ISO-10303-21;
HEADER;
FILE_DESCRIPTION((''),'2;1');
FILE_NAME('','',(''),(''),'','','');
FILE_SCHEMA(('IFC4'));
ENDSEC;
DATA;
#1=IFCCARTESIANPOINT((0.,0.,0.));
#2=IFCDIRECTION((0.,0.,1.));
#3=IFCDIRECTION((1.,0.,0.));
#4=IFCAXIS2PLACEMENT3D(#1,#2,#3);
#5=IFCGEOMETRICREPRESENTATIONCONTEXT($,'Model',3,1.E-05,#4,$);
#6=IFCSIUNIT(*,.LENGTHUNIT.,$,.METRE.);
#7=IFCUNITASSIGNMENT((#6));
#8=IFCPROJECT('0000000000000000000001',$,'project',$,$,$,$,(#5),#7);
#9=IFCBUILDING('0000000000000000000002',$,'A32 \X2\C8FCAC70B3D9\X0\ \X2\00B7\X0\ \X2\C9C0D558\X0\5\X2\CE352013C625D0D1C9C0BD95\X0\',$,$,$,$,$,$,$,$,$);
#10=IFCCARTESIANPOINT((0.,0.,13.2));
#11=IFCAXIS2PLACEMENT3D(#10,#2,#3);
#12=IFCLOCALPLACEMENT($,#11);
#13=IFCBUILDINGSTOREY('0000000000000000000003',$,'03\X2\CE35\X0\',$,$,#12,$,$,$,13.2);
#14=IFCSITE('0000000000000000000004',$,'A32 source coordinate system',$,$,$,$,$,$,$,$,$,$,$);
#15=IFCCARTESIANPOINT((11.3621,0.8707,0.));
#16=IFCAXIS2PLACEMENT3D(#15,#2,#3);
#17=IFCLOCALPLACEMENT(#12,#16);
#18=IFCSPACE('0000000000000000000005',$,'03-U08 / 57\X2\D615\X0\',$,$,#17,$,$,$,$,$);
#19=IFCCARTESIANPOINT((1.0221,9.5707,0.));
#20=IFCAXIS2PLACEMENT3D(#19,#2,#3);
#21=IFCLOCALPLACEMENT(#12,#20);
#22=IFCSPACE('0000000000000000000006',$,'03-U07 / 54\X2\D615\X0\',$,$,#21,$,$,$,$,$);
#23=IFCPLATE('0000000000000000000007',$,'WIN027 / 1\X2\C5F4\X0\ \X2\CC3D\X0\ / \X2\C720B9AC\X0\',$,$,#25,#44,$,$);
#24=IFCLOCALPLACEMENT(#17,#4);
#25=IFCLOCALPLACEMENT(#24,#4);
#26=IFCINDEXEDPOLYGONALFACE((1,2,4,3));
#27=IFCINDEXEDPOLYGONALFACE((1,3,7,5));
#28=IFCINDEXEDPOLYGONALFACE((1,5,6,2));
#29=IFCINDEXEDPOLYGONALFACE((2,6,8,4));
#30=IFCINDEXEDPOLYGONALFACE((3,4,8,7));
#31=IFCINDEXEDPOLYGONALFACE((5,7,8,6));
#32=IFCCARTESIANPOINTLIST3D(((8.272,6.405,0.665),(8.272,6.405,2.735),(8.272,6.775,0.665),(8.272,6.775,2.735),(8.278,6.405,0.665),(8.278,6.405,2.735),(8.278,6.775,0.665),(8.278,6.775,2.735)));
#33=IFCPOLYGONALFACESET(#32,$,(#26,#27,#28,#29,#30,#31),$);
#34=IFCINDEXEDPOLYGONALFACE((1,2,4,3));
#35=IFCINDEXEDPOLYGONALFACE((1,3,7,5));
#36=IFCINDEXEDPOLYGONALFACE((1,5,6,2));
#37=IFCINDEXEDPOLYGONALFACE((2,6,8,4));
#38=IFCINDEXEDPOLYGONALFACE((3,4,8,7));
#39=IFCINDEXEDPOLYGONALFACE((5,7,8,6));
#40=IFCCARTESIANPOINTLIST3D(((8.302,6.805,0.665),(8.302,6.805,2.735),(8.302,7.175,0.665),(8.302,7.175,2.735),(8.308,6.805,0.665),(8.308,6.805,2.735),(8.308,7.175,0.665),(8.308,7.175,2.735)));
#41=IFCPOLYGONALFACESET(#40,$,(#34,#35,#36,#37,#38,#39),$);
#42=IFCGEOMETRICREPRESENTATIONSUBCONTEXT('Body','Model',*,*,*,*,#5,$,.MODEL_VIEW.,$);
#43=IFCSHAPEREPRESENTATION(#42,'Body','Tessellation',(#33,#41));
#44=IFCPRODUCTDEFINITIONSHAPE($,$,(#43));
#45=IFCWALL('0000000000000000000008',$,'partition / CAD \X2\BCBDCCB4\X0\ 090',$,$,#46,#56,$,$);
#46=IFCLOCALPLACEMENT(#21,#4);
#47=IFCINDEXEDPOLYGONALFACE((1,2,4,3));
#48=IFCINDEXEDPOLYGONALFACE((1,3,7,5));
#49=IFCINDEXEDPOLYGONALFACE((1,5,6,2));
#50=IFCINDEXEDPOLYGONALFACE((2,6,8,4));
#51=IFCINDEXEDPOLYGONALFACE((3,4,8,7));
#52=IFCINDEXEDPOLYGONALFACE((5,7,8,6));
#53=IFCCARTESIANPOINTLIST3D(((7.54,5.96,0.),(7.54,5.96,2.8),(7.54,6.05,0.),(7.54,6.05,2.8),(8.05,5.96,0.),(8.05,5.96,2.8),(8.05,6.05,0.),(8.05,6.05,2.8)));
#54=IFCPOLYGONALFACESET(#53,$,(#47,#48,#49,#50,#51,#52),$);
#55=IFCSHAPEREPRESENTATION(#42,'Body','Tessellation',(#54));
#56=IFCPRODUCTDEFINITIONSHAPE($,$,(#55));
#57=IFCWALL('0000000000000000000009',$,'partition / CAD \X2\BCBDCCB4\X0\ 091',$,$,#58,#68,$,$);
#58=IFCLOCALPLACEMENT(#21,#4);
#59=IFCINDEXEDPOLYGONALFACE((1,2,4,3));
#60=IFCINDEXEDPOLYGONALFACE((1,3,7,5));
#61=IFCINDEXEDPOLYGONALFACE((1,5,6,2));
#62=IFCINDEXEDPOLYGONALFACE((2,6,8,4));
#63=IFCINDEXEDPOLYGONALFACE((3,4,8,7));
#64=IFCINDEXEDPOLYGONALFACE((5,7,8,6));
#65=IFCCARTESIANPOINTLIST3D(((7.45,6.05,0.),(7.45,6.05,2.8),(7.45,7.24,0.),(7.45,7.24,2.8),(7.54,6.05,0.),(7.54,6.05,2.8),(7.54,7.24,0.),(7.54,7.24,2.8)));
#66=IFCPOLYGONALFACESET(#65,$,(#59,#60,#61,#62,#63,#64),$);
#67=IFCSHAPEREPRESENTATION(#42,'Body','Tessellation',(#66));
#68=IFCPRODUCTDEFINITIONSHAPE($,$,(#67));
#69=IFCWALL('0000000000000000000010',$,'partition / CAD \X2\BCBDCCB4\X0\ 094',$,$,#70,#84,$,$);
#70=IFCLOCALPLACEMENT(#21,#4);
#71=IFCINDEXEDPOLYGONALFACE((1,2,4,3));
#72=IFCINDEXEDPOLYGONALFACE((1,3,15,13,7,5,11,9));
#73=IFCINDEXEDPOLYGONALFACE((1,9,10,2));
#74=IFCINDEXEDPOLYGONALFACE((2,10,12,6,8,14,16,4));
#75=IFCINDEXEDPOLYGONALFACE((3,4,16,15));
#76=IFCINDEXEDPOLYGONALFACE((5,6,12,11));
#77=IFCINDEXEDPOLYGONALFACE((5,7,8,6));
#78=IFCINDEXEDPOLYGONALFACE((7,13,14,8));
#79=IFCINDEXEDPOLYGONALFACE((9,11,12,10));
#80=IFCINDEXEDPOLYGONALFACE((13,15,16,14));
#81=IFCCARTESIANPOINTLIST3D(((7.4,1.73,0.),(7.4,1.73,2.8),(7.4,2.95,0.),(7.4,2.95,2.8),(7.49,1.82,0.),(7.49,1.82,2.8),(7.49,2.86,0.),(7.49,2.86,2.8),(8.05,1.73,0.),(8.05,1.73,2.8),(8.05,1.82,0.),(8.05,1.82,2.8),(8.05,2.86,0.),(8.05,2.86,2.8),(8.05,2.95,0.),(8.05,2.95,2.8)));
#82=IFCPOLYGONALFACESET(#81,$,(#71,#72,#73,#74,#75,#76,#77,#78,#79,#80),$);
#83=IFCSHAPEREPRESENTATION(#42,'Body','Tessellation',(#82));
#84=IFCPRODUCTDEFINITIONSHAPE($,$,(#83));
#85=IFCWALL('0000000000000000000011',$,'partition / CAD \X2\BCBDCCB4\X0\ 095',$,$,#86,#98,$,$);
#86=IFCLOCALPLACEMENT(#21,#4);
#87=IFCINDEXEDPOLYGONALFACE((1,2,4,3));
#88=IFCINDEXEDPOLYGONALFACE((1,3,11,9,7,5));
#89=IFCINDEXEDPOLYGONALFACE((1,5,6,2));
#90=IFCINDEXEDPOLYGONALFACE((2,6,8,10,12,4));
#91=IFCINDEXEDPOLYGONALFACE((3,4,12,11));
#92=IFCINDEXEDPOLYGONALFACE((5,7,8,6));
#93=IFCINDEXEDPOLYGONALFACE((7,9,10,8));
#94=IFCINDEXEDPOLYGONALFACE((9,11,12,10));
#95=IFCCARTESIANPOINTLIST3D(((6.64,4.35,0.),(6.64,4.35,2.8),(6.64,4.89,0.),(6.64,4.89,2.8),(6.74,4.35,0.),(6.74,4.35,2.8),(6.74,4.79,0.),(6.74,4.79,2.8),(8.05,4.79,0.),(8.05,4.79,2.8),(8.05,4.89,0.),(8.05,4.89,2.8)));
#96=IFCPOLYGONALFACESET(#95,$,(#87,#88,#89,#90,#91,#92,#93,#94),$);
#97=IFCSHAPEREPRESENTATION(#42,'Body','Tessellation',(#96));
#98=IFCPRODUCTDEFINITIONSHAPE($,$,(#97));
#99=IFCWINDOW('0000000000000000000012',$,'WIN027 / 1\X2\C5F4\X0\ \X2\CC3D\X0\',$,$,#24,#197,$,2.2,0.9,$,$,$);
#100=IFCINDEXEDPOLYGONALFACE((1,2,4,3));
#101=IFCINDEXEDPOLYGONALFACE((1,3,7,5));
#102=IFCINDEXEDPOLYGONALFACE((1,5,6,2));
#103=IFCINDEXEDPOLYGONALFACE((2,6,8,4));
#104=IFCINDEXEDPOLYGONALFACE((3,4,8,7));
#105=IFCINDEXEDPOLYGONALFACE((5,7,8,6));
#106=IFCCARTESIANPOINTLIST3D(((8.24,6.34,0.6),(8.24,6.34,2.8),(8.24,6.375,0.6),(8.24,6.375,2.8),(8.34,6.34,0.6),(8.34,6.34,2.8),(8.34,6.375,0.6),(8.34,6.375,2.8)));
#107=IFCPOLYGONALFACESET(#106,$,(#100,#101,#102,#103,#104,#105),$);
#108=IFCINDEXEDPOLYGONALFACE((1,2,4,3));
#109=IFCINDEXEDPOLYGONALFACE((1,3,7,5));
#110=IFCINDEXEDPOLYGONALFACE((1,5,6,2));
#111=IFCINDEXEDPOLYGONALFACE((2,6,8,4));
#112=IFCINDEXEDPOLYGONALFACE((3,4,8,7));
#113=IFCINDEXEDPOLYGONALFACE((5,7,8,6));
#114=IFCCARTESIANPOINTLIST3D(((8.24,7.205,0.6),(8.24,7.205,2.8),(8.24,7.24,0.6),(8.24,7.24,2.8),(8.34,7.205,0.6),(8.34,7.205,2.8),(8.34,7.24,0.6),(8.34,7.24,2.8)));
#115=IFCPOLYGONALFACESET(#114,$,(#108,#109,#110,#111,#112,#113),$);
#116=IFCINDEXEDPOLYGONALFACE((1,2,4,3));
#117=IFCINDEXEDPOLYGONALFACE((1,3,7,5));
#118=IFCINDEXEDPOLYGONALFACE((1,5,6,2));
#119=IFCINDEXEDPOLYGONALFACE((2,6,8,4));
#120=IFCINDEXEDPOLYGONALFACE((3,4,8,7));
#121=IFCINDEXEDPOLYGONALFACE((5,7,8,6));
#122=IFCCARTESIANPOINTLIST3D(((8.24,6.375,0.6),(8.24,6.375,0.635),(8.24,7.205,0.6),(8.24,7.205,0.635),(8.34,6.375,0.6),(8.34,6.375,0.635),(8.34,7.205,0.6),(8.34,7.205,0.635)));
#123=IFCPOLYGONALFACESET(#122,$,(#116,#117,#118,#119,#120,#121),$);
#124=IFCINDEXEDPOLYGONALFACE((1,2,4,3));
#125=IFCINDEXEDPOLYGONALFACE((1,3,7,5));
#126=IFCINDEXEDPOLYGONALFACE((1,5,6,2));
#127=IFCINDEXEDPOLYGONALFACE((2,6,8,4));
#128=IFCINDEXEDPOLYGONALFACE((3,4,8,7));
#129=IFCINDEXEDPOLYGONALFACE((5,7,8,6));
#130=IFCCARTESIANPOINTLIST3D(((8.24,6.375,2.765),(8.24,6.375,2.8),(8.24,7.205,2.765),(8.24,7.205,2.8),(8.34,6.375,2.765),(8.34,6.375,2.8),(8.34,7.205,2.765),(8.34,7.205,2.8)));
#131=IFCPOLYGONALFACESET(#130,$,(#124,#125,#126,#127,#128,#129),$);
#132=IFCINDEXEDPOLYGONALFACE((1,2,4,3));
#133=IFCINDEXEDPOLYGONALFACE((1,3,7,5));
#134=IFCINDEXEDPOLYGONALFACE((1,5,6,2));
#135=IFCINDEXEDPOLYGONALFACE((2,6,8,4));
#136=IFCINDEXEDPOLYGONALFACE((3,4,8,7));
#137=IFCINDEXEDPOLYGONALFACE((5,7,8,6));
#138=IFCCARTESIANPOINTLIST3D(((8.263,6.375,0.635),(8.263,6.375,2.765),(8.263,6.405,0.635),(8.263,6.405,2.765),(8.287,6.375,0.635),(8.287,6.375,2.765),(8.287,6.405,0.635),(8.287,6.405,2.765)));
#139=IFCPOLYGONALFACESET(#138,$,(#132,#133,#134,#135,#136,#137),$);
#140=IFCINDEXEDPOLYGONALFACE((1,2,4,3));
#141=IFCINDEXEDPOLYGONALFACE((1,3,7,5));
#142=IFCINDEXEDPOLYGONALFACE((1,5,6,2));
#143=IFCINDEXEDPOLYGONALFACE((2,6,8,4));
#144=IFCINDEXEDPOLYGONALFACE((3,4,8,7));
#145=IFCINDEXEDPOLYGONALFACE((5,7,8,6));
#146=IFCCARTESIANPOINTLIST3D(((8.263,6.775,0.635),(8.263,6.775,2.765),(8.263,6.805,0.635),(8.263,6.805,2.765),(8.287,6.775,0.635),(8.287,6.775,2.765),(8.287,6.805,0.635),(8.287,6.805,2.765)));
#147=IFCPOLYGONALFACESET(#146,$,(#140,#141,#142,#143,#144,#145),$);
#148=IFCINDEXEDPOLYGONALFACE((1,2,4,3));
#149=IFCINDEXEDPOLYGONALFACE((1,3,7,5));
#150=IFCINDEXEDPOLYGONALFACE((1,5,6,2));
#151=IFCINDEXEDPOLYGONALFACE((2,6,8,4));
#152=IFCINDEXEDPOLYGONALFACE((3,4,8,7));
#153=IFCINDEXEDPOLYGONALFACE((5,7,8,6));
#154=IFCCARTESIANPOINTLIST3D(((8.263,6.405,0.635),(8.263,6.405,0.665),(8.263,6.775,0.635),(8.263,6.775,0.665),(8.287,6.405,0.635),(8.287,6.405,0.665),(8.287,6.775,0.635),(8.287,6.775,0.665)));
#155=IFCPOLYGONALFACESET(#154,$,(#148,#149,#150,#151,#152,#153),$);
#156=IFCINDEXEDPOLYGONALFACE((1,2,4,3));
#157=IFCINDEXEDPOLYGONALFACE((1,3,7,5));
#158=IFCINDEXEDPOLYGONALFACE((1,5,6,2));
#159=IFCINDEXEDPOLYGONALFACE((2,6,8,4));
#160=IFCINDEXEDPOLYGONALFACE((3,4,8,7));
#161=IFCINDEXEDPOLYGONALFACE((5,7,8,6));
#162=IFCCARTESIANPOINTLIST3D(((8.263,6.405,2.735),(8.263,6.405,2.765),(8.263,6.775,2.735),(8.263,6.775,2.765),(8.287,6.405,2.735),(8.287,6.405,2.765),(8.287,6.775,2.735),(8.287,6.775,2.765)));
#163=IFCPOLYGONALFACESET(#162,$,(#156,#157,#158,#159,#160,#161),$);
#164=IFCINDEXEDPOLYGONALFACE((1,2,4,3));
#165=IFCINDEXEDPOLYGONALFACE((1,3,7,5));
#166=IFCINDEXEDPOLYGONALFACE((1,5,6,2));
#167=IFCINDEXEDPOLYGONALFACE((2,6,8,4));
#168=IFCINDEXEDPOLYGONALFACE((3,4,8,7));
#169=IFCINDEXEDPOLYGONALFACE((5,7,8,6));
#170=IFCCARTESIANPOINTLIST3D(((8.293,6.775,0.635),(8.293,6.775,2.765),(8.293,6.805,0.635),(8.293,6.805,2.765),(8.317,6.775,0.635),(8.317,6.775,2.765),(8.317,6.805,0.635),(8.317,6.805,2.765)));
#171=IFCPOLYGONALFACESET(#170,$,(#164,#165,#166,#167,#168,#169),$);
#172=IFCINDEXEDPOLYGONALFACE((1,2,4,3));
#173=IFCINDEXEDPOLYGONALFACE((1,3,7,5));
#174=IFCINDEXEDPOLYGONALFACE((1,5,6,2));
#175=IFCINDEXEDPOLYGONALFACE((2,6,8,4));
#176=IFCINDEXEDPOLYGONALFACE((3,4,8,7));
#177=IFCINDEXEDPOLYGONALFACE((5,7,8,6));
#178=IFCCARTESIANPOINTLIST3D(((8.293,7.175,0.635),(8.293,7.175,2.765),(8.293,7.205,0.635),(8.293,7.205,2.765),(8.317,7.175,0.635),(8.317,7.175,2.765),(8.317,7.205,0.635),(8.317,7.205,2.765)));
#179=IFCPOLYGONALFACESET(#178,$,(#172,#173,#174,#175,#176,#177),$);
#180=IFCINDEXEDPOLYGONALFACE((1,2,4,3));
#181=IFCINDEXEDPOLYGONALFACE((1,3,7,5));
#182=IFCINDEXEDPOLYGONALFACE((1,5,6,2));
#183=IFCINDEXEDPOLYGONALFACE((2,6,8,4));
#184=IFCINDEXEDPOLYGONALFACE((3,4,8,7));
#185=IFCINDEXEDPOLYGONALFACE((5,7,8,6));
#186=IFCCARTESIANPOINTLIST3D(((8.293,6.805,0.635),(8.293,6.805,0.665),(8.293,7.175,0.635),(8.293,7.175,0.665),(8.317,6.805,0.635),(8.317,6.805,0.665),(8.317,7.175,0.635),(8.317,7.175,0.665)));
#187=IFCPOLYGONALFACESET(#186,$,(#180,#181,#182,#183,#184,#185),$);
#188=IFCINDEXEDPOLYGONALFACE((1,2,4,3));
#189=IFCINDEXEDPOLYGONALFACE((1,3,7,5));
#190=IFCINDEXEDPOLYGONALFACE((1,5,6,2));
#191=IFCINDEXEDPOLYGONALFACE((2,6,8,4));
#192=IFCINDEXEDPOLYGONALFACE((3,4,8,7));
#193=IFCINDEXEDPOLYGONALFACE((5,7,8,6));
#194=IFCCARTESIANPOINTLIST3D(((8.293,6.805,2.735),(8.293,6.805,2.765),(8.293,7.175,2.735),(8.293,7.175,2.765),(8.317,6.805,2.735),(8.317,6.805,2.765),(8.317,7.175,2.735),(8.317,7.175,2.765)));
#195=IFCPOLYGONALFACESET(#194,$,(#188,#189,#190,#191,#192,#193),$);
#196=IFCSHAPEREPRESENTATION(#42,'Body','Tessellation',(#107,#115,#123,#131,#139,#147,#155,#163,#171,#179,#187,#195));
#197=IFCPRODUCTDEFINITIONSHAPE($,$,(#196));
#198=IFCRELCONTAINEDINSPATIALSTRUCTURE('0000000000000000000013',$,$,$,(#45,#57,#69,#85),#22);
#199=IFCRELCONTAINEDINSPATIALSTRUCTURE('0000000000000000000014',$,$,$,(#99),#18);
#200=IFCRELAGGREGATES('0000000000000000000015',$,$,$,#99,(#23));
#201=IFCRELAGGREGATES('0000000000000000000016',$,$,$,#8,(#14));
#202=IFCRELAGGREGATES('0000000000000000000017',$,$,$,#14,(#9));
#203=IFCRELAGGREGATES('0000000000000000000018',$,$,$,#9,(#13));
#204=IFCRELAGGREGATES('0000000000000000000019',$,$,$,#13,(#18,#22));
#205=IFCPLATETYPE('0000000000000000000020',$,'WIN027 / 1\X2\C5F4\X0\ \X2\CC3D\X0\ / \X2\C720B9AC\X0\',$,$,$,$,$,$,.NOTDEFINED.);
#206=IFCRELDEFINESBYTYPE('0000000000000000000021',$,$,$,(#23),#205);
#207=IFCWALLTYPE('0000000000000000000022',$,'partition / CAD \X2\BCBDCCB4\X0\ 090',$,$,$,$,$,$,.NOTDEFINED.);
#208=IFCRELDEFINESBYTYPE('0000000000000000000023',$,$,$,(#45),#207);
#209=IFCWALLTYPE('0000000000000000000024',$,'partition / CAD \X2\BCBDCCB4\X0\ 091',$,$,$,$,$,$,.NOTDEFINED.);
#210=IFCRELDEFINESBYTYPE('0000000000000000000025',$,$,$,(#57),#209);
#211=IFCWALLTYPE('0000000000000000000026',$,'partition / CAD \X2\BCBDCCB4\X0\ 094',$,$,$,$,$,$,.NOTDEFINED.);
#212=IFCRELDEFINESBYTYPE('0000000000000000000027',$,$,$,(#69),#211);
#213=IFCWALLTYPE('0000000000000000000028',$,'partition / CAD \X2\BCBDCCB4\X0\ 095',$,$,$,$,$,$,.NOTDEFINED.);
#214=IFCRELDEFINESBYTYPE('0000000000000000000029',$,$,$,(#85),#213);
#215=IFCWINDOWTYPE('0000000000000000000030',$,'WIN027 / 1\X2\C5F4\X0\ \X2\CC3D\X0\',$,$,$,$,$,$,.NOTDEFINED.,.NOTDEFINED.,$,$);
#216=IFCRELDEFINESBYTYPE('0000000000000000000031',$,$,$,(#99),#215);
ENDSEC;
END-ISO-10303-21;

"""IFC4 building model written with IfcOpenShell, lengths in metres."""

from ifc_helpers import new_model, si_unit, frame, origin, origin_with_axes, place, context, subcontext, project, spatial, polyline, outline, extrude, source, transform, mapped, type_object, type_shapes, element, aggregate, save


model = new_model("IFC4")

# Units and contexts
model_context = context("Model", 3, precision=1e-05, world=origin_with_axes())
body_context = subcontext(model_context, "Body", "Model", "MODEL_VIEW")
ifc_project = project(units=[si_unit("LENGTHUNIT", "METRE")], contexts=[model_context])

# Plate
plate_type = type_object("IfcPlateType", Name="WIN027 / 1열 창 / 유리", PredefinedType="NOTDEFINED")
shared_shape_1 = source(origin(), body_context, "Body", "SweptSolid", [
    extrude(outline(polyline([(8.272, 6.405), (8.272, 6.775), (8.278, 6.775), (8.278, 6.405), (8.272, 6.405)])), frame((0.0, 0.0, 0.665)), (0.0, 0.0, 1.0), 2.07),
    extrude(outline(polyline([(8.302, 6.805), (8.302, 7.175), (8.308, 7.175), (8.308, 6.805), (8.302, 6.805)])), frame((0.0, 0.0, 0.665)), (0.0, 0.0, 1.0), 2.07),
])
type_shapes(plate_type, [shared_shape_1])
storey_placement = place(None, frame((0.0, 0.0, 13.2), z_axis=(0.0, 0.0, 1.0), x_axis=(1.0, 0.0, 0.0)))
space_1_placement = place(storey_placement, frame((11.3621, 0.8707, 0.0), z_axis=(0.0, 0.0, 1.0), x_axis=(1.0, 0.0, 0.0)))
window_placement = place(space_1_placement, origin_with_axes())
plate_placement = place(window_placement, origin_with_axes())
plate = element("IfcPlate", 1, at=plate_placement, type_object=plate_type, Name="WIN027 / 1열 창 / 유리", context=body_context, shape_type="MappedRepresentation", body=[
    mapped(shared_shape_1, transform((0.0, 0.0, 0.0), scale=1.0)),
])

# Site, building, storey, space
site = spatial("IfcSite", under=ifc_project, Name="A32 source coordinate system")
building = spatial("IfcBuilding", under=site, Name="A32 주거동 · 지하5층–옥탑지붕")
storey = spatial("IfcBuildingStorey", under=building, at=storey_placement, Name="03층", Elevation=13.2)
space_1 = spatial("IfcSpace", under=storey, at=space_1_placement, Name="03-U08 / 57형")

# Shared definitions
space_2_placement = place(storey_placement, frame((1.0221, 9.5707, 0.0), z_axis=(0.0, 0.0, 1.0), x_axis=(1.0, 0.0, 0.0)))
space_2 = spatial("IfcSpace", under=storey, at=space_2_placement, Name="03-U07 / 54형")

# Walls
wall_type_1 = type_object("IfcWallType", Name="partition / CAD 벽체 090", PredefinedType="NOTDEFINED")
shared_shape_2 = source(origin(), body_context, "Body", "SweptSolid", [
    extrude(outline(polyline([(7.54, 5.96), (7.54, 6.05), (8.05, 6.05), (8.05, 5.96), (7.54, 5.96)])), origin(), (0.0, 0.0, 1.0), 2.8),
])
type_shapes(wall_type_1, [shared_shape_2])
wall_1_placement = place(space_2_placement, origin_with_axes())
element("IfcWall", 2, at=wall_1_placement, inside=space_2, type_object=wall_type_1, Name="partition / CAD 벽체 090", context=body_context, shape_type="MappedRepresentation", body=[
    mapped(shared_shape_2, transform((0.0, 0.0, 0.0), scale=1.0)),
])
wall_type_2 = type_object("IfcWallType", Name="partition / CAD 벽체 091", PredefinedType="NOTDEFINED")
shared_shape_3 = source(origin(), body_context, "Body", "SweptSolid", [
    extrude(outline(polyline([(7.54, 6.05), (7.45, 6.05), (7.45, 7.24), (7.54, 7.24), (7.54, 6.05)])), origin(), (0.0, 0.0, 1.0), 2.8),
])
type_shapes(wall_type_2, [shared_shape_3])
wall_2_placement = place(space_2_placement, origin_with_axes())
element("IfcWall", 3, at=wall_2_placement, inside=space_2, type_object=wall_type_2, Name="partition / CAD 벽체 091", context=body_context, shape_type="MappedRepresentation", body=[
    mapped(shared_shape_3, transform((0.0, 0.0, 0.0), scale=1.0)),
])
wall_type_3 = type_object("IfcWallType", Name="partition / CAD 벽체 094", PredefinedType="NOTDEFINED")
shared_shape_4 = source(origin(), body_context, "Body", "SweptSolid", [
    extrude(outline(polyline([(8.05, 1.73), (7.4, 1.73), (7.4, 2.95), (8.05, 2.95), (8.05, 2.86), (7.49, 2.86), (7.49, 1.82), (8.05, 1.82), (8.05, 1.73)])), origin(), (0.0, 0.0, 1.0), 2.8),
])
type_shapes(wall_type_3, [shared_shape_4])
wall_3_placement = place(space_2_placement, origin_with_axes())
element("IfcWall", 4, at=wall_3_placement, inside=space_2, type_object=wall_type_3, Name="partition / CAD 벽체 094", context=body_context, shape_type="MappedRepresentation", body=[
    mapped(shared_shape_4, transform((0.0, 0.0, 0.0), scale=1.0)),
])
wall_type_4 = type_object("IfcWallType", Name="partition / CAD 벽체 095", PredefinedType="NOTDEFINED")
shared_shape_5 = source(origin(), body_context, "Body", "SweptSolid", [
    extrude(outline(polyline([(6.64, 4.89), (8.05, 4.89), (8.05, 4.79), (6.74, 4.79), (6.74, 4.35), (6.64, 4.35), (6.64, 4.89)])), origin(), (0.0, 0.0, 1.0), 2.8),
])
type_shapes(wall_type_4, [shared_shape_5])
wall_4_placement = place(space_2_placement, origin_with_axes())
element("IfcWall", 5, at=wall_4_placement, inside=space_2, type_object=wall_type_4, Name="partition / CAD 벽체 095", context=body_context, shape_type="MappedRepresentation", body=[
    mapped(shared_shape_5, transform((0.0, 0.0, 0.0), scale=1.0)),
])

# Window
window_type = type_object("IfcWindowType", Name="WIN027 / 1열 창", PartitioningType="NOTDEFINED", PredefinedType="NOTDEFINED")
shared_shape_6 = source(origin(), body_context, "Body", "SweptSolid", [
    extrude(outline(polyline([(8.24, 6.34), (8.24, 6.375), (8.34, 6.375), (8.34, 6.34), (8.24, 6.34)])), frame((0.0, 0.0, 0.6)), (0.0, 0.0, 1.0), 2.2),
    extrude(outline(polyline([(8.24, 7.205), (8.24, 7.24), (8.34, 7.24), (8.34, 7.205), (8.24, 7.205)])), frame((0.0, 0.0, 0.6)), (0.0, 0.0, 1.0), 2.2),
    extrude(outline(polyline([(8.24, 6.375), (8.24, 7.205), (8.34, 7.205), (8.34, 6.375), (8.24, 6.375)])), frame((0.0, 0.0, 0.6)), (0.0, 0.0, 1.0), 0.035),
    extrude(outline(polyline([(8.24, 6.375), (8.24, 7.205), (8.34, 7.205), (8.34, 6.375), (8.24, 6.375)])), frame((0.0, 0.0, 2.765)), (0.0, 0.0, 1.0), 0.035),
    extrude(outline(polyline([(8.263, 6.375), (8.263, 6.405), (8.287, 6.405), (8.287, 6.375), (8.263, 6.375)])), frame((0.0, 0.0, 0.635)), (0.0, 0.0, 1.0), 2.13),
    extrude(outline(polyline([(8.263, 6.775), (8.263, 6.805), (8.287, 6.805), (8.287, 6.775), (8.263, 6.775)])), frame((0.0, 0.0, 0.635)), (0.0, 0.0, 1.0), 2.13),
    extrude(outline(polyline([(8.263, 6.405), (8.263, 6.775), (8.287, 6.775), (8.287, 6.405), (8.263, 6.405)])), frame((0.0, 0.0, 0.635)), (0.0, 0.0, 1.0), 0.03),
    extrude(outline(polyline([(8.263, 6.405), (8.263, 6.775), (8.287, 6.775), (8.287, 6.405), (8.263, 6.405)])), frame((0.0, 0.0, 2.735)), (0.0, 0.0, 1.0), 0.03),
    extrude(outline(polyline([(8.293, 6.775), (8.293, 6.805), (8.317, 6.805), (8.317, 6.775), (8.293, 6.775)])), frame((0.0, 0.0, 0.635)), (0.0, 0.0, 1.0), 2.13),
    extrude(outline(polyline([(8.293, 7.175), (8.293, 7.205), (8.317, 7.205), (8.317, 7.175), (8.293, 7.175)])), frame((0.0, 0.0, 0.635)), (0.0, 0.0, 1.0), 2.13),
    extrude(outline(polyline([(8.293, 6.805), (8.293, 7.175), (8.317, 7.175), (8.317, 6.805), (8.293, 6.805)])), frame((0.0, 0.0, 0.635)), (0.0, 0.0, 1.0), 0.03),
    extrude(outline(polyline([(8.293, 6.805), (8.293, 7.175), (8.317, 7.175), (8.317, 6.805), (8.293, 6.805)])), frame((0.0, 0.0, 2.735)), (0.0, 0.0, 1.0), 0.03),
])
type_shapes(window_type, [shared_shape_6])
window = element("IfcWindow", 6, at=window_placement, inside=space_1, type_object=window_type, Name="WIN027 / 1열 창", OverallHeight=2.2, OverallWidth=0.9, context=body_context, shape_type="MappedRepresentation", body=[
    mapped(shared_shape_6, transform((0.0, 0.0, 0.0), scale=1.0)),
])
aggregate(window, [plate])

save(model, "model.ifc")
